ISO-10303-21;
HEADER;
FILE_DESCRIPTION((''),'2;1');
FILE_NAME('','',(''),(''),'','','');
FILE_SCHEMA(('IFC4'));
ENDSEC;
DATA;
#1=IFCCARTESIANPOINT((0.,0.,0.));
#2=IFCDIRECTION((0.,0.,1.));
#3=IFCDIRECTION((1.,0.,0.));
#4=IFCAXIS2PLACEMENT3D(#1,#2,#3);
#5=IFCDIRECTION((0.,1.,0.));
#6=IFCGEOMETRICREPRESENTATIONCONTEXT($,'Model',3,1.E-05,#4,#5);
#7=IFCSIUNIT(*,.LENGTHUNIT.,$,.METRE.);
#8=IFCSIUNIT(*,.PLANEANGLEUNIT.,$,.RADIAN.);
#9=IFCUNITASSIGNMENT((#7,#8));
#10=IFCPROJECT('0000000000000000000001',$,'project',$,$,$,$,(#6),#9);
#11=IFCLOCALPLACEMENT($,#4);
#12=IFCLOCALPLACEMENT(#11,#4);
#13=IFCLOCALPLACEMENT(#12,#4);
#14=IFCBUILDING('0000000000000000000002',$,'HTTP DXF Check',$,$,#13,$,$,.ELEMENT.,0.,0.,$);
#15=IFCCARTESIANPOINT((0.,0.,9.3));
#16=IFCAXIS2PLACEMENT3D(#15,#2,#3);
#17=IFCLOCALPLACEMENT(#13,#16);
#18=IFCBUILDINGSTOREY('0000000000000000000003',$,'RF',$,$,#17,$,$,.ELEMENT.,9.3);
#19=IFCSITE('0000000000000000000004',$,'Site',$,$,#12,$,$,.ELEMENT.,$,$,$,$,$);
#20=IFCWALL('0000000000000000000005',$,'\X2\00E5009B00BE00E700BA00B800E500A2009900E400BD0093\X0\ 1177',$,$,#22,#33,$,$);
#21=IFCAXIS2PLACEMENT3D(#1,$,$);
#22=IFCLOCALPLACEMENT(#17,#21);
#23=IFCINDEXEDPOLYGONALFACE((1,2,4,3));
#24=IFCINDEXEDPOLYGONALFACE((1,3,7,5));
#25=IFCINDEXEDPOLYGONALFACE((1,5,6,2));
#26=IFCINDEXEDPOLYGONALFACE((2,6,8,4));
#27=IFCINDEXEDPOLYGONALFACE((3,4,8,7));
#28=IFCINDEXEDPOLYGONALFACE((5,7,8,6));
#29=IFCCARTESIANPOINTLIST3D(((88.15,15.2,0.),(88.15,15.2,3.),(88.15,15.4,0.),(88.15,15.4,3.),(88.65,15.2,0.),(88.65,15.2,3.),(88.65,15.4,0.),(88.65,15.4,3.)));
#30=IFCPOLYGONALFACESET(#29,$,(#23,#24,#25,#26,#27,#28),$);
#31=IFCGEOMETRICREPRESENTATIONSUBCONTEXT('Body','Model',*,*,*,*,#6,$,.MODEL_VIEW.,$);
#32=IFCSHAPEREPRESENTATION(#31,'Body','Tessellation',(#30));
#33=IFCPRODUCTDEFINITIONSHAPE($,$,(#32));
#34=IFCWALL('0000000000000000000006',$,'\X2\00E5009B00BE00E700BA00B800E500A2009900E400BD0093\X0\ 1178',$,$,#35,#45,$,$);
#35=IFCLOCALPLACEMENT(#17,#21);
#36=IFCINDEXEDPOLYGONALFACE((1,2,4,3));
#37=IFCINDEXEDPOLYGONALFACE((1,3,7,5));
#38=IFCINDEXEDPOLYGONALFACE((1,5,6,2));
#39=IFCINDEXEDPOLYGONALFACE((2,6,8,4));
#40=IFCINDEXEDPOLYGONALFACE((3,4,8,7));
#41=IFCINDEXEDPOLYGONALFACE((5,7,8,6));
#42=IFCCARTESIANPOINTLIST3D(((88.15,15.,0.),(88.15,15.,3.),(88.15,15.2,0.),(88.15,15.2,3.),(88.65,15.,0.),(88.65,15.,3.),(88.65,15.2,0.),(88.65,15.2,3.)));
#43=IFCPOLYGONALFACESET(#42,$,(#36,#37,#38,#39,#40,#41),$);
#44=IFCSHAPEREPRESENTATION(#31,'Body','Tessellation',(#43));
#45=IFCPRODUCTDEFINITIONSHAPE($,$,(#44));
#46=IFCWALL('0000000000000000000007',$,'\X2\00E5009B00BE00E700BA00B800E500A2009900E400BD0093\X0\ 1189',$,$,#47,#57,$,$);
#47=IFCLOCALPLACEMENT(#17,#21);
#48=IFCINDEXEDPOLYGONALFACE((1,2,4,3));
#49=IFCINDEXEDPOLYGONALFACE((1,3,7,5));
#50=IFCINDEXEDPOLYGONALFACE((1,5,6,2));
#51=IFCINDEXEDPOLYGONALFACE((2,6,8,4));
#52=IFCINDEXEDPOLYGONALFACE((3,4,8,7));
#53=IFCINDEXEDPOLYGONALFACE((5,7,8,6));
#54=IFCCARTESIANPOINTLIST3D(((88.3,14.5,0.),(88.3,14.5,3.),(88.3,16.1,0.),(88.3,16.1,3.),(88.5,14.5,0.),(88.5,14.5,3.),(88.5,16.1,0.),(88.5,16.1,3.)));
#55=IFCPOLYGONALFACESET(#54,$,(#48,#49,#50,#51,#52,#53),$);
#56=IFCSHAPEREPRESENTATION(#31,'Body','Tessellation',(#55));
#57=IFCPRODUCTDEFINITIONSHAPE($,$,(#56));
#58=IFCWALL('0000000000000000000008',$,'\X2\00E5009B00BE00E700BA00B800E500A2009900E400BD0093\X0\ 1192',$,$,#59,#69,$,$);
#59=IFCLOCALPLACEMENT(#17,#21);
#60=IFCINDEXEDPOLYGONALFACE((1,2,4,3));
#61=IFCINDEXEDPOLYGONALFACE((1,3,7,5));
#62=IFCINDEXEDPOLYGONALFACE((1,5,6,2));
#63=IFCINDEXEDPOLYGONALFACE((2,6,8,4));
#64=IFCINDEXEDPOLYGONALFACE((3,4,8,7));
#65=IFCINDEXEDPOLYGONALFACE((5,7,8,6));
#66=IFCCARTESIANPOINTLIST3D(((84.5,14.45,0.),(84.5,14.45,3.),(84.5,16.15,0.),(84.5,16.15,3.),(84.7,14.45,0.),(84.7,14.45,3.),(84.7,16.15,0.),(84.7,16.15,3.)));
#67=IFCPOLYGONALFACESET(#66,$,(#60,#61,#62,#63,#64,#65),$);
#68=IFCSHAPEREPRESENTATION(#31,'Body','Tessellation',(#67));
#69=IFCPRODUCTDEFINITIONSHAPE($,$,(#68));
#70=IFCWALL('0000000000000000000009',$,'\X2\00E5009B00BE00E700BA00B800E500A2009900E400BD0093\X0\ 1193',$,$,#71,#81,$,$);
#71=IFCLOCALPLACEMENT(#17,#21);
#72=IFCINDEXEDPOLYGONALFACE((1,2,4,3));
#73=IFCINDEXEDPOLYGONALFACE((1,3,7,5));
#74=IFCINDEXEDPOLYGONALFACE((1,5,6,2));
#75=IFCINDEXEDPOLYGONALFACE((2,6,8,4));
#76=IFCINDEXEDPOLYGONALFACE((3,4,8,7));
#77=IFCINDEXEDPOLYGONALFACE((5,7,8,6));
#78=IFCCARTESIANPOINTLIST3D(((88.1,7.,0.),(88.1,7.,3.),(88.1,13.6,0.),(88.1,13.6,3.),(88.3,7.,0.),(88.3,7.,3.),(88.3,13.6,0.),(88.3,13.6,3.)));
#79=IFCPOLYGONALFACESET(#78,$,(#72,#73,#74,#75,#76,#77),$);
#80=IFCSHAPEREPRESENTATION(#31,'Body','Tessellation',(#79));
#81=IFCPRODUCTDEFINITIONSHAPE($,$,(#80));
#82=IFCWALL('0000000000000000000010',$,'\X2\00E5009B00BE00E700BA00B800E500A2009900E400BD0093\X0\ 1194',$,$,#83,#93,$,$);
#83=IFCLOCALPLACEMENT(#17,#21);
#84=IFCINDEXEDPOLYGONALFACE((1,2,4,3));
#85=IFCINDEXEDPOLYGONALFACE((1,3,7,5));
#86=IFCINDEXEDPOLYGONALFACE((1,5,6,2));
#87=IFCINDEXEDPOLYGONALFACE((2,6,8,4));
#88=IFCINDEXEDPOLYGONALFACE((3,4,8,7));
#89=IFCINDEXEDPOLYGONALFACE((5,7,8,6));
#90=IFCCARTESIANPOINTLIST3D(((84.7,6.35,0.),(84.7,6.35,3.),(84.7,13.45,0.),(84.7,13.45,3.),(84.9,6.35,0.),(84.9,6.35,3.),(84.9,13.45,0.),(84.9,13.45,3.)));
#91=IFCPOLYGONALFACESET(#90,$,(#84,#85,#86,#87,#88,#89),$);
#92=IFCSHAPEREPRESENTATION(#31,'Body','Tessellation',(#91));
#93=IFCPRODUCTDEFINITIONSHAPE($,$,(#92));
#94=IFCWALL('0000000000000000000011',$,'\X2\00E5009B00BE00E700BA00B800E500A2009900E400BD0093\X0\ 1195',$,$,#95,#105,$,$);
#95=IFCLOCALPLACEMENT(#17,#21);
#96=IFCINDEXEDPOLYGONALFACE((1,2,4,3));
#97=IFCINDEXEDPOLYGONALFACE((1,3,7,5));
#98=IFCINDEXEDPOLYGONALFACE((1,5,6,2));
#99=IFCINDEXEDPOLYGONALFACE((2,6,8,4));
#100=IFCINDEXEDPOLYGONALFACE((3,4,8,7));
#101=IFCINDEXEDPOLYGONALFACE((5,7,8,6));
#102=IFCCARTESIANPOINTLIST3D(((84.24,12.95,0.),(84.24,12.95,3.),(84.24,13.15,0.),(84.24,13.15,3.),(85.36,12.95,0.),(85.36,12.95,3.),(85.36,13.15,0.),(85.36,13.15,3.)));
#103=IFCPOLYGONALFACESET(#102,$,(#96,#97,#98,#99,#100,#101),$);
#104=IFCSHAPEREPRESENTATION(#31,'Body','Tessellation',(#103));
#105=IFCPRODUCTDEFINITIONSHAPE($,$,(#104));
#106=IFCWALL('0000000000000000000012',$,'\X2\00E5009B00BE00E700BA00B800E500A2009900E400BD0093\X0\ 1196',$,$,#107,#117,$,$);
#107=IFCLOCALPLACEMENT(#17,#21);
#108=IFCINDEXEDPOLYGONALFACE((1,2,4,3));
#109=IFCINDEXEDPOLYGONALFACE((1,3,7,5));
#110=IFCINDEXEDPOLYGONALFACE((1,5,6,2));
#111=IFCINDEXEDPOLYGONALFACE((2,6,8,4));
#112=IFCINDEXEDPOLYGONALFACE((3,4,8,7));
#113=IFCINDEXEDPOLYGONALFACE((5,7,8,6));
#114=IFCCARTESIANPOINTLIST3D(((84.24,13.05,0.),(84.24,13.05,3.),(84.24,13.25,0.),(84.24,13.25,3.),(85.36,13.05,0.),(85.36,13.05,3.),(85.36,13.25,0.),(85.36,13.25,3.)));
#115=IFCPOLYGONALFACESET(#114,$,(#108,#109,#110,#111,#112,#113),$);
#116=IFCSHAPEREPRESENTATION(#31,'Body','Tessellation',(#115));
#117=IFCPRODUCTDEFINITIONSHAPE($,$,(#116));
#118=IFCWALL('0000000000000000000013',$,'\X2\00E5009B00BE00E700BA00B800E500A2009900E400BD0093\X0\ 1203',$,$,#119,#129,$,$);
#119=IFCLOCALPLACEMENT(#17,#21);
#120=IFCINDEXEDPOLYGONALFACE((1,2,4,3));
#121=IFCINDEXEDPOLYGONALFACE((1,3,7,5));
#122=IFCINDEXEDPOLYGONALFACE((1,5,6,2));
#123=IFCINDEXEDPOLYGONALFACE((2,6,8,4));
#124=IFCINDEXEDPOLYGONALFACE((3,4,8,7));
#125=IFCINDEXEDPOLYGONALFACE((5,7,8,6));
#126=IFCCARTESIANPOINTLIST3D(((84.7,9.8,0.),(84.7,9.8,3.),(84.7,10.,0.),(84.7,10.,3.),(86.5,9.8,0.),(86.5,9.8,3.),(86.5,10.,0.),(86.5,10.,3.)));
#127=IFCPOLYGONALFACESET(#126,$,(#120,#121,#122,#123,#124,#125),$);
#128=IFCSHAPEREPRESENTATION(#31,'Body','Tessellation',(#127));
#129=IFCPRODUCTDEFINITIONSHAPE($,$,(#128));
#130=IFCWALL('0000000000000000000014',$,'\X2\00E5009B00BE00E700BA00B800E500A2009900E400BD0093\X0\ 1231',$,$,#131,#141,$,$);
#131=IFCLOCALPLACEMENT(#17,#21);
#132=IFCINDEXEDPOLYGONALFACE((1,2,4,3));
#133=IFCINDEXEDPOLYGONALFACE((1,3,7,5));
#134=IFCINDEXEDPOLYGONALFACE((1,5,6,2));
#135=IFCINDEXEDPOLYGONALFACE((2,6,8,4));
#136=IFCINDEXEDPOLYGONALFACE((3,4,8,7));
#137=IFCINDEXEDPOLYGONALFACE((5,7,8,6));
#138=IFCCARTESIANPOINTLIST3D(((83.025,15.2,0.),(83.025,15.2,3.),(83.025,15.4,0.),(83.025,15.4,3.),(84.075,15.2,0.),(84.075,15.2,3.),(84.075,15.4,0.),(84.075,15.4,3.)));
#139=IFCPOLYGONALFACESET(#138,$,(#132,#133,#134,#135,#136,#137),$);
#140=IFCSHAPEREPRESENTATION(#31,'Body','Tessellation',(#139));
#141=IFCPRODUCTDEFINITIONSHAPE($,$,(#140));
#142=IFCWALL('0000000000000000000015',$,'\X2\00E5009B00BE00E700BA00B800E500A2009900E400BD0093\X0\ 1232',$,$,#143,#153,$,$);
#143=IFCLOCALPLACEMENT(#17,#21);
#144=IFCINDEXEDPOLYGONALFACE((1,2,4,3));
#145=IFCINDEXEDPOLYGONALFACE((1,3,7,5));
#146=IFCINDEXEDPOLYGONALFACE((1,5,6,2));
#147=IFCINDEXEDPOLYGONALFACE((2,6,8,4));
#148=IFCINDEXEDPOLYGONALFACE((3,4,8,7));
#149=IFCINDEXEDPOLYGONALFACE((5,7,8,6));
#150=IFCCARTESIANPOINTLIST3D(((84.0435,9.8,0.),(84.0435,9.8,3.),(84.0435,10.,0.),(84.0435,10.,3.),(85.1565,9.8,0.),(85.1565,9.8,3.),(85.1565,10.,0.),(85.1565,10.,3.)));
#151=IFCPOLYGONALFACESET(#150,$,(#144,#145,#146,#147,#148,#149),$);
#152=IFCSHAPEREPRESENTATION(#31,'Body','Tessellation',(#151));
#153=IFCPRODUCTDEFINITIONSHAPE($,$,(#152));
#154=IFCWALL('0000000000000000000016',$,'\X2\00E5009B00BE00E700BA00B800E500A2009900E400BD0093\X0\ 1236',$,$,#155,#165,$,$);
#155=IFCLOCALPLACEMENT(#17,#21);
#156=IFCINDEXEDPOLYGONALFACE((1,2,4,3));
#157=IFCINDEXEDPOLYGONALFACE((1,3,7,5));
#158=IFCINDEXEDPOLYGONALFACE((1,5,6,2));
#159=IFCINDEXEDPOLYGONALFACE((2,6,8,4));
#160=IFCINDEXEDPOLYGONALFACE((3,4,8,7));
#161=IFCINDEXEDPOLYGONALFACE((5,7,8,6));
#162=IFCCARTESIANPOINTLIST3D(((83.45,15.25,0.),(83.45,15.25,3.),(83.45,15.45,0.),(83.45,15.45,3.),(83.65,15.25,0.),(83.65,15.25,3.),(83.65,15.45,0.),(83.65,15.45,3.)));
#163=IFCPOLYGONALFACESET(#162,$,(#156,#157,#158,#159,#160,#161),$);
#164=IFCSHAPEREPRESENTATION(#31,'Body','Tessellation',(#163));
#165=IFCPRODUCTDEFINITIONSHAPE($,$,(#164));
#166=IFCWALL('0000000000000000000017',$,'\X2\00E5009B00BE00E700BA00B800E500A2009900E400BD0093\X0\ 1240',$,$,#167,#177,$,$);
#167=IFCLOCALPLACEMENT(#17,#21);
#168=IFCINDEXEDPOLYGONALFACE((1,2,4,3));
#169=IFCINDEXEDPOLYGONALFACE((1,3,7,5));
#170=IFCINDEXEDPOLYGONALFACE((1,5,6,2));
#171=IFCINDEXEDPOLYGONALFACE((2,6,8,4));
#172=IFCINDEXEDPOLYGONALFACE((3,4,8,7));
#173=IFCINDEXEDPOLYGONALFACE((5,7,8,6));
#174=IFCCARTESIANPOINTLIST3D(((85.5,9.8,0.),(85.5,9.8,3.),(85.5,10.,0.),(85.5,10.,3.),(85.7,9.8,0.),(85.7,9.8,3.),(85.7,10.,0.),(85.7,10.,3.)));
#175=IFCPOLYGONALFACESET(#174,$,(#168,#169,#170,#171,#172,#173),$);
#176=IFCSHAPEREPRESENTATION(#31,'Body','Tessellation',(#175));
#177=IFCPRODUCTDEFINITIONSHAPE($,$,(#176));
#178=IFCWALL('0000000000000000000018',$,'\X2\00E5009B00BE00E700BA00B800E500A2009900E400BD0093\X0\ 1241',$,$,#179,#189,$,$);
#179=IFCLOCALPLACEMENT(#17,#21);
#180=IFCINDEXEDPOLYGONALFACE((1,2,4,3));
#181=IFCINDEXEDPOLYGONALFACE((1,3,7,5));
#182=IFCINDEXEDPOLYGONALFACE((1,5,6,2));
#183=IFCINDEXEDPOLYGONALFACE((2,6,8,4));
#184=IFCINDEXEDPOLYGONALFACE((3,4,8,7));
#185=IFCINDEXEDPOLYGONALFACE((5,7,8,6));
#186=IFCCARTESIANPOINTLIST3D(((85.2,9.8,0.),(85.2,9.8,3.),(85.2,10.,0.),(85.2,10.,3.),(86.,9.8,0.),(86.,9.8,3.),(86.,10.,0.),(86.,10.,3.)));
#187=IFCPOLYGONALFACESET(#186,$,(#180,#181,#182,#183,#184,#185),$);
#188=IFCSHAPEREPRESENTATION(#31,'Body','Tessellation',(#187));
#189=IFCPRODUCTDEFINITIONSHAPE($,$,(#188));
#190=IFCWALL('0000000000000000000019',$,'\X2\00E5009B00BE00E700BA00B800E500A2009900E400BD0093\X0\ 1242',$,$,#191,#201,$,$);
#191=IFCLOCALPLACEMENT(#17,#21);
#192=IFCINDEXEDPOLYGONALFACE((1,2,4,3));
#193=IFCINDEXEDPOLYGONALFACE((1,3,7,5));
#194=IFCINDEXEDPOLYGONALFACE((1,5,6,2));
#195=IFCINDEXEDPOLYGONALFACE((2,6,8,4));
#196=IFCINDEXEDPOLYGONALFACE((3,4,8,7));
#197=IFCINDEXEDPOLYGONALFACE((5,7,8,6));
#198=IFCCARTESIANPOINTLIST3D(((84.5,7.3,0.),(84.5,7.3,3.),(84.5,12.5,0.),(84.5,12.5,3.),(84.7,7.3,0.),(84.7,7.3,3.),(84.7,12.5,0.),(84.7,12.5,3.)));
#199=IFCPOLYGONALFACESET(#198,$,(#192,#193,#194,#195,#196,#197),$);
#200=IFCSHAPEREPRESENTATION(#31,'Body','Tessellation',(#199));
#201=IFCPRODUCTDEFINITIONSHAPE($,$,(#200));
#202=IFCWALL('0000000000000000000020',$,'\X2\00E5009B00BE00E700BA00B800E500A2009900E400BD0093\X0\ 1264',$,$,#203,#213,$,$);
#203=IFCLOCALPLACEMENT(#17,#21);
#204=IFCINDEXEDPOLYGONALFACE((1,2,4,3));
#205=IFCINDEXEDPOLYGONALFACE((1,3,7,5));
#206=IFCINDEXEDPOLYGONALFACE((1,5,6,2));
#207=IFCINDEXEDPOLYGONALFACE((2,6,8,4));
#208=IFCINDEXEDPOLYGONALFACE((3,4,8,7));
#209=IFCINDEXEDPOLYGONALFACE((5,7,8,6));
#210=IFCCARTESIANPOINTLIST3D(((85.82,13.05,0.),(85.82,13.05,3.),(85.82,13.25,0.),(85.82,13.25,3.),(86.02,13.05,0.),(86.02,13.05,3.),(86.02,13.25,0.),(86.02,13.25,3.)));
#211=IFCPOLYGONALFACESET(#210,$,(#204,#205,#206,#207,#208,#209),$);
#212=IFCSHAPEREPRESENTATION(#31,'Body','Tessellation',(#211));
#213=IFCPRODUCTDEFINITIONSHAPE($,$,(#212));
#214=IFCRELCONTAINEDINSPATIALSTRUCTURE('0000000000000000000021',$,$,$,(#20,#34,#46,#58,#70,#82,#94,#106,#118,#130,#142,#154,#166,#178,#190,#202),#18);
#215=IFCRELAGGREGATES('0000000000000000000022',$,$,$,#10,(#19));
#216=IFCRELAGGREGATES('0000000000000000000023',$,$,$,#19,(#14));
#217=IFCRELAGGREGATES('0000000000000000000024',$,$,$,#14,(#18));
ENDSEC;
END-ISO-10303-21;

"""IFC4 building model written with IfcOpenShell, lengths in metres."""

from ifc_helpers import new_model, si_unit, direction, frame, frame_2d, origin_with_axes, place, context, subcontext, project, spatial, rectangle, extrude, element, save


model = new_model("IFC4")

# Units and contexts
model_context = context("Model", 3, precision=1e-05, world=origin_with_axes(), true_north=direction((0.0, 1.0, 0.0)))
body_context = subcontext(model_context, "Body", "Model", "MODEL_VIEW")
ifc_project = project(units=[si_unit("LENGTHUNIT", "METRE"), si_unit("PLANEANGLEUNIT", "RADIAN")], contexts=[model_context])

# Site, building, storey
placement = place(None, origin_with_axes())
site_placement = place(placement, origin_with_axes())
site = spatial("IfcSite", under=ifc_project, at=site_placement, Name="Site", CompositionType="ELEMENT")
building_placement = place(site_placement, origin_with_axes())
building = spatial("IfcBuilding", under=site, at=building_placement, Name="HTTP DXF Check", CompositionType="ELEMENT", ElevationOfRefHeight=0.0, ElevationOfTerrain=0.0)
storey_placement = place(building_placement, frame((0.0, 0.0, 9.3), z_axis=(0.0, 0.0, 1.0), x_axis=(1.0, 0.0, 0.0)))
storey = spatial("IfcBuildingStorey", under=building, at=storey_placement, Name="RF", CompositionType="ELEMENT", Elevation=9.3)

# Walls
for number, where, z_axis, x_axis, name in (
    (1, (88.4, 15.3, 0.0), (0.0, 0.0, 1.0), (1.0, 0.0, 0.0), "å\u009b¾çº¸å¢\u0099ä½\u0093 1177"),
    (2, (88.4, 15.1, 0.0), (0.0, 0.0, 1.0), (1.0, 0.0, 0.0), "å\u009b¾çº¸å¢\u0099ä½\u0093 1178"),
):
    element("IfcWall", number, at=place(storey_placement, frame(where, z_axis=z_axis, x_axis=x_axis)), inside=storey, Name=name, context=body_context, shape_type="SweptSolid", body=[
        extrude(rectangle(XDim=0.5, YDim=0.2, at=frame_2d((0.0, 0.0), x_axis=(1.0, 0.0, 0.0))), frame((0.0, 0.0, 0.0), z_axis=(0.0, 0.0, 1.0)), (0.0, 0.0, 1.0), 3.0),
    ])
wall_1_placement = place(storey_placement, frame((88.4, 15.3, 0.0), z_axis=(0.0, 0.0, 1.0), x_axis=(0.0, 1.0, 0.0)))
element("IfcWall", 3, at=wall_1_placement, inside=storey, Name="å\u009b¾çº¸å¢\u0099ä½\u0093 1189", context=body_context, shape_type="SweptSolid", body=[
    extrude(rectangle(XDim=1.6, YDim=0.2, at=frame_2d((0.0, 0.0), x_axis=(1.0, 0.0, 0.0))), frame((0.0, 0.0, 0.0), z_axis=(0.0, 0.0, 1.0)), (0.0, 0.0, 1.0), 3.0),
])
wall_2_placement = place(storey_placement, frame((84.6, 15.3, 0.0), z_axis=(0.0, 0.0, 1.0), x_axis=(0.0, 1.0, 0.0)))
element("IfcWall", 4, at=wall_2_placement, inside=storey, Name="å\u009b¾çº¸å¢\u0099ä½\u0093 1192", context=body_context, shape_type="SweptSolid", body=[
    extrude(rectangle(XDim=1.7, YDim=0.2, at=frame_2d((0.0, 0.0), x_axis=(1.0, 0.0, 0.0))), frame((0.0, 0.0, 0.0), z_axis=(0.0, 0.0, 1.0)), (0.0, 0.0, 1.0), 3.0),
])
wall_3_placement = place(storey_placement, frame((88.2, 10.3, 0.0), z_axis=(0.0, 0.0, 1.0), x_axis=(0.0, 1.0, 0.0)))
element("IfcWall", 5, at=wall_3_placement, inside=storey, Name="å\u009b¾çº¸å¢\u0099ä½\u0093 1193", context=body_context, shape_type="SweptSolid", body=[
    extrude(rectangle(XDim=6.6, YDim=0.2, at=frame_2d((0.0, 0.0), x_axis=(1.0, 0.0, 0.0))), frame((0.0, 0.0, 0.0), z_axis=(0.0, 0.0, 1.0)), (0.0, 0.0, 1.0), 3.0),
])
wall_4_placement = place(storey_placement, frame((84.8, 9.9, 0.0), z_axis=(0.0, 0.0, 1.0), x_axis=(0.0, 1.0, 0.0)))
element("IfcWall", 6, at=wall_4_placement, inside=storey, Name="å\u009b¾çº¸å¢\u0099ä½\u0093 1194", context=body_context, shape_type="SweptSolid", body=[
    extrude(rectangle(XDim=7.1, YDim=0.2, at=frame_2d((0.0, 0.0), x_axis=(1.0, 0.0, 0.0))), frame((0.0, 0.0, 0.0), z_axis=(0.0, 0.0, 1.0)), (0.0, 0.0, 1.0), 3.0),
])
for number, where, z_axis, x_axis, name in (
    (7, (84.8, 13.05, 0.0), (0.0, 0.0, 1.0), (1.0, 0.0, 0.0), "å\u009b¾çº¸å¢\u0099ä½\u0093 1195"),
    (8, (84.8, 13.15, 0.0), (0.0, 0.0, 1.0), (1.0, 0.0, 0.0), "å\u009b¾çº¸å¢\u0099ä½\u0093 1196"),
):
    element("IfcWall", number, at=place(storey_placement, frame(where, z_axis=z_axis, x_axis=x_axis)), inside=storey, Name=name, context=body_context, shape_type="SweptSolid", body=[
        extrude(rectangle(XDim=1.12, YDim=0.2, at=frame_2d((0.0, 0.0), x_axis=(1.0, 0.0, 0.0))), frame((0.0, 0.0, 0.0), z_axis=(0.0, 0.0, 1.0)), (0.0, 0.0, 1.0), 3.0),
    ])
wall_5_placement = place(storey_placement, frame((85.6, 9.9, 0.0), z_axis=(0.0, 0.0, 1.0), x_axis=(1.0, 0.0, 0.0)))
element("IfcWall", 9, at=wall_5_placement, inside=storey, Name="å\u009b¾çº¸å¢\u0099ä½\u0093 1203", context=body_context, shape_type="SweptSolid", body=[
    extrude(rectangle(XDim=1.8, YDim=0.2, at=frame_2d((0.0, 0.0), x_axis=(1.0, 0.0, 0.0))), frame((0.0, 0.0, 0.0), z_axis=(0.0, 0.0, 1.0)), (0.0, 0.0, 1.0), 3.0),
])
wall_6_placement = place(storey_placement, frame((83.55, 15.3, 0.0), z_axis=(0.0, 0.0, 1.0), x_axis=(1.0, 0.0, 0.0)))
element("IfcWall", 10, at=wall_6_placement, inside=storey, Name="å\u009b¾çº¸å¢\u0099ä½\u0093 1231", context=body_context, shape_type="SweptSolid", body=[
    extrude(rectangle(XDim=1.05, YDim=0.2, at=frame_2d((0.0, 0.0), x_axis=(1.0, 0.0, 0.0))), frame((0.0, 0.0, 0.0), z_axis=(0.0, 0.0, 1.0)), (0.0, 0.0, 1.0), 3.0),
])
wall_7_placement = place(storey_placement, frame((84.6, 9.9, 0.0), z_axis=(0.0, 0.0, 1.0), x_axis=(-1.0, 0.0, 0.0)))
element("IfcWall", 11, at=wall_7_placement, inside=storey, Name="å\u009b¾çº¸å¢\u0099ä½\u0093 1232", context=body_context, shape_type="SweptSolid", body=[
    extrude(rectangle(XDim=1.113, YDim=0.2, at=frame_2d((0.0, 0.0), x_axis=(1.0, 0.0, 0.0))), frame((0.0, 0.0, 0.0), z_axis=(0.0, 0.0, 1.0)), (0.0, 0.0, 1.0), 3.0),
])
for number, where, z_axis, x_axis, name in (
    (12, (83.55, 15.35, 0.0), (0.0, 0.0, 1.0), (-1.0, 0.0, 0.0), "å\u009b¾çº¸å¢\u0099ä½\u0093 1236"),
    (13, (85.6, 9.9, 0.0), (0.0, 0.0, 1.0), (0.0, -1.0, 0.0), "å\u009b¾çº¸å¢\u0099ä½\u0093 1240"),
):
    element("IfcWall", number, at=place(storey_placement, frame(where, z_axis=z_axis, x_axis=x_axis)), inside=storey, Name=name, context=body_context, shape_type="SweptSolid", body=[
        extrude(rectangle(XDim=0.2, YDim=0.2, at=frame_2d((0.0, 0.0), x_axis=(1.0, 0.0, 0.0))), frame((0.0, 0.0, 0.0), z_axis=(0.0, 0.0, 1.0)), (0.0, 0.0, 1.0), 3.0),
    ])
wall_8_placement = place(storey_placement, frame((85.6, 9.9, 0.0), z_axis=(0.0, 0.0, 1.0), x_axis=(-1.0, 0.0, 0.0)))
element("IfcWall", 14, at=wall_8_placement, inside=storey, Name="å\u009b¾çº¸å¢\u0099ä½\u0093 1241", context=body_context, shape_type="SweptSolid", body=[
    extrude(rectangle(XDim=0.8, YDim=0.2, at=frame_2d((0.0, 0.0), x_axis=(1.0, 0.0, 0.0))), frame((0.0, 0.0, 0.0), z_axis=(0.0, 0.0, 1.0)), (0.0, 0.0, 1.0), 3.0),
])
wall_9_placement = place(storey_placement, frame((84.6, 9.9, 0.0), z_axis=(0.0, 0.0, 1.0), x_axis=(0.0, 1.0, 0.0)))
element("IfcWall", 15, at=wall_9_placement, inside=storey, Name="å\u009b¾çº¸å¢\u0099ä½\u0093 1242", context=body_context, shape_type="SweptSolid", body=[
    extrude(rectangle(XDim=5.2, YDim=0.2, at=frame_2d((0.0, 0.0), x_axis=(1.0, 0.0, 0.0))), frame((0.0, 0.0, 0.0), z_axis=(0.0, 0.0, 1.0)), (0.0, 0.0, 1.0), 3.0),
])
for number, where, z_axis, x_axis, name in (
    (16, (85.92, 13.15, 0.0), (0.0, 0.0, 1.0), (0.0, -1.0, 0.0), "å\u009b¾çº¸å¢\u0099ä½\u0093 1264"),
):
    element("IfcWall", number, at=place(storey_placement, frame(where, z_axis=z_axis, x_axis=x_axis)), inside=storey, Name=name, context=body_context, shape_type="SweptSolid", body=[
        extrude(rectangle(XDim=0.2, YDim=0.2, at=frame_2d((0.0, 0.0), x_axis=(1.0, 0.0, 0.0))), frame((0.0, 0.0, 0.0), z_axis=(0.0, 0.0, 1.0)), (0.0, 0.0, 1.0), 3.0),
    ])

save(model, "model.ifc")
